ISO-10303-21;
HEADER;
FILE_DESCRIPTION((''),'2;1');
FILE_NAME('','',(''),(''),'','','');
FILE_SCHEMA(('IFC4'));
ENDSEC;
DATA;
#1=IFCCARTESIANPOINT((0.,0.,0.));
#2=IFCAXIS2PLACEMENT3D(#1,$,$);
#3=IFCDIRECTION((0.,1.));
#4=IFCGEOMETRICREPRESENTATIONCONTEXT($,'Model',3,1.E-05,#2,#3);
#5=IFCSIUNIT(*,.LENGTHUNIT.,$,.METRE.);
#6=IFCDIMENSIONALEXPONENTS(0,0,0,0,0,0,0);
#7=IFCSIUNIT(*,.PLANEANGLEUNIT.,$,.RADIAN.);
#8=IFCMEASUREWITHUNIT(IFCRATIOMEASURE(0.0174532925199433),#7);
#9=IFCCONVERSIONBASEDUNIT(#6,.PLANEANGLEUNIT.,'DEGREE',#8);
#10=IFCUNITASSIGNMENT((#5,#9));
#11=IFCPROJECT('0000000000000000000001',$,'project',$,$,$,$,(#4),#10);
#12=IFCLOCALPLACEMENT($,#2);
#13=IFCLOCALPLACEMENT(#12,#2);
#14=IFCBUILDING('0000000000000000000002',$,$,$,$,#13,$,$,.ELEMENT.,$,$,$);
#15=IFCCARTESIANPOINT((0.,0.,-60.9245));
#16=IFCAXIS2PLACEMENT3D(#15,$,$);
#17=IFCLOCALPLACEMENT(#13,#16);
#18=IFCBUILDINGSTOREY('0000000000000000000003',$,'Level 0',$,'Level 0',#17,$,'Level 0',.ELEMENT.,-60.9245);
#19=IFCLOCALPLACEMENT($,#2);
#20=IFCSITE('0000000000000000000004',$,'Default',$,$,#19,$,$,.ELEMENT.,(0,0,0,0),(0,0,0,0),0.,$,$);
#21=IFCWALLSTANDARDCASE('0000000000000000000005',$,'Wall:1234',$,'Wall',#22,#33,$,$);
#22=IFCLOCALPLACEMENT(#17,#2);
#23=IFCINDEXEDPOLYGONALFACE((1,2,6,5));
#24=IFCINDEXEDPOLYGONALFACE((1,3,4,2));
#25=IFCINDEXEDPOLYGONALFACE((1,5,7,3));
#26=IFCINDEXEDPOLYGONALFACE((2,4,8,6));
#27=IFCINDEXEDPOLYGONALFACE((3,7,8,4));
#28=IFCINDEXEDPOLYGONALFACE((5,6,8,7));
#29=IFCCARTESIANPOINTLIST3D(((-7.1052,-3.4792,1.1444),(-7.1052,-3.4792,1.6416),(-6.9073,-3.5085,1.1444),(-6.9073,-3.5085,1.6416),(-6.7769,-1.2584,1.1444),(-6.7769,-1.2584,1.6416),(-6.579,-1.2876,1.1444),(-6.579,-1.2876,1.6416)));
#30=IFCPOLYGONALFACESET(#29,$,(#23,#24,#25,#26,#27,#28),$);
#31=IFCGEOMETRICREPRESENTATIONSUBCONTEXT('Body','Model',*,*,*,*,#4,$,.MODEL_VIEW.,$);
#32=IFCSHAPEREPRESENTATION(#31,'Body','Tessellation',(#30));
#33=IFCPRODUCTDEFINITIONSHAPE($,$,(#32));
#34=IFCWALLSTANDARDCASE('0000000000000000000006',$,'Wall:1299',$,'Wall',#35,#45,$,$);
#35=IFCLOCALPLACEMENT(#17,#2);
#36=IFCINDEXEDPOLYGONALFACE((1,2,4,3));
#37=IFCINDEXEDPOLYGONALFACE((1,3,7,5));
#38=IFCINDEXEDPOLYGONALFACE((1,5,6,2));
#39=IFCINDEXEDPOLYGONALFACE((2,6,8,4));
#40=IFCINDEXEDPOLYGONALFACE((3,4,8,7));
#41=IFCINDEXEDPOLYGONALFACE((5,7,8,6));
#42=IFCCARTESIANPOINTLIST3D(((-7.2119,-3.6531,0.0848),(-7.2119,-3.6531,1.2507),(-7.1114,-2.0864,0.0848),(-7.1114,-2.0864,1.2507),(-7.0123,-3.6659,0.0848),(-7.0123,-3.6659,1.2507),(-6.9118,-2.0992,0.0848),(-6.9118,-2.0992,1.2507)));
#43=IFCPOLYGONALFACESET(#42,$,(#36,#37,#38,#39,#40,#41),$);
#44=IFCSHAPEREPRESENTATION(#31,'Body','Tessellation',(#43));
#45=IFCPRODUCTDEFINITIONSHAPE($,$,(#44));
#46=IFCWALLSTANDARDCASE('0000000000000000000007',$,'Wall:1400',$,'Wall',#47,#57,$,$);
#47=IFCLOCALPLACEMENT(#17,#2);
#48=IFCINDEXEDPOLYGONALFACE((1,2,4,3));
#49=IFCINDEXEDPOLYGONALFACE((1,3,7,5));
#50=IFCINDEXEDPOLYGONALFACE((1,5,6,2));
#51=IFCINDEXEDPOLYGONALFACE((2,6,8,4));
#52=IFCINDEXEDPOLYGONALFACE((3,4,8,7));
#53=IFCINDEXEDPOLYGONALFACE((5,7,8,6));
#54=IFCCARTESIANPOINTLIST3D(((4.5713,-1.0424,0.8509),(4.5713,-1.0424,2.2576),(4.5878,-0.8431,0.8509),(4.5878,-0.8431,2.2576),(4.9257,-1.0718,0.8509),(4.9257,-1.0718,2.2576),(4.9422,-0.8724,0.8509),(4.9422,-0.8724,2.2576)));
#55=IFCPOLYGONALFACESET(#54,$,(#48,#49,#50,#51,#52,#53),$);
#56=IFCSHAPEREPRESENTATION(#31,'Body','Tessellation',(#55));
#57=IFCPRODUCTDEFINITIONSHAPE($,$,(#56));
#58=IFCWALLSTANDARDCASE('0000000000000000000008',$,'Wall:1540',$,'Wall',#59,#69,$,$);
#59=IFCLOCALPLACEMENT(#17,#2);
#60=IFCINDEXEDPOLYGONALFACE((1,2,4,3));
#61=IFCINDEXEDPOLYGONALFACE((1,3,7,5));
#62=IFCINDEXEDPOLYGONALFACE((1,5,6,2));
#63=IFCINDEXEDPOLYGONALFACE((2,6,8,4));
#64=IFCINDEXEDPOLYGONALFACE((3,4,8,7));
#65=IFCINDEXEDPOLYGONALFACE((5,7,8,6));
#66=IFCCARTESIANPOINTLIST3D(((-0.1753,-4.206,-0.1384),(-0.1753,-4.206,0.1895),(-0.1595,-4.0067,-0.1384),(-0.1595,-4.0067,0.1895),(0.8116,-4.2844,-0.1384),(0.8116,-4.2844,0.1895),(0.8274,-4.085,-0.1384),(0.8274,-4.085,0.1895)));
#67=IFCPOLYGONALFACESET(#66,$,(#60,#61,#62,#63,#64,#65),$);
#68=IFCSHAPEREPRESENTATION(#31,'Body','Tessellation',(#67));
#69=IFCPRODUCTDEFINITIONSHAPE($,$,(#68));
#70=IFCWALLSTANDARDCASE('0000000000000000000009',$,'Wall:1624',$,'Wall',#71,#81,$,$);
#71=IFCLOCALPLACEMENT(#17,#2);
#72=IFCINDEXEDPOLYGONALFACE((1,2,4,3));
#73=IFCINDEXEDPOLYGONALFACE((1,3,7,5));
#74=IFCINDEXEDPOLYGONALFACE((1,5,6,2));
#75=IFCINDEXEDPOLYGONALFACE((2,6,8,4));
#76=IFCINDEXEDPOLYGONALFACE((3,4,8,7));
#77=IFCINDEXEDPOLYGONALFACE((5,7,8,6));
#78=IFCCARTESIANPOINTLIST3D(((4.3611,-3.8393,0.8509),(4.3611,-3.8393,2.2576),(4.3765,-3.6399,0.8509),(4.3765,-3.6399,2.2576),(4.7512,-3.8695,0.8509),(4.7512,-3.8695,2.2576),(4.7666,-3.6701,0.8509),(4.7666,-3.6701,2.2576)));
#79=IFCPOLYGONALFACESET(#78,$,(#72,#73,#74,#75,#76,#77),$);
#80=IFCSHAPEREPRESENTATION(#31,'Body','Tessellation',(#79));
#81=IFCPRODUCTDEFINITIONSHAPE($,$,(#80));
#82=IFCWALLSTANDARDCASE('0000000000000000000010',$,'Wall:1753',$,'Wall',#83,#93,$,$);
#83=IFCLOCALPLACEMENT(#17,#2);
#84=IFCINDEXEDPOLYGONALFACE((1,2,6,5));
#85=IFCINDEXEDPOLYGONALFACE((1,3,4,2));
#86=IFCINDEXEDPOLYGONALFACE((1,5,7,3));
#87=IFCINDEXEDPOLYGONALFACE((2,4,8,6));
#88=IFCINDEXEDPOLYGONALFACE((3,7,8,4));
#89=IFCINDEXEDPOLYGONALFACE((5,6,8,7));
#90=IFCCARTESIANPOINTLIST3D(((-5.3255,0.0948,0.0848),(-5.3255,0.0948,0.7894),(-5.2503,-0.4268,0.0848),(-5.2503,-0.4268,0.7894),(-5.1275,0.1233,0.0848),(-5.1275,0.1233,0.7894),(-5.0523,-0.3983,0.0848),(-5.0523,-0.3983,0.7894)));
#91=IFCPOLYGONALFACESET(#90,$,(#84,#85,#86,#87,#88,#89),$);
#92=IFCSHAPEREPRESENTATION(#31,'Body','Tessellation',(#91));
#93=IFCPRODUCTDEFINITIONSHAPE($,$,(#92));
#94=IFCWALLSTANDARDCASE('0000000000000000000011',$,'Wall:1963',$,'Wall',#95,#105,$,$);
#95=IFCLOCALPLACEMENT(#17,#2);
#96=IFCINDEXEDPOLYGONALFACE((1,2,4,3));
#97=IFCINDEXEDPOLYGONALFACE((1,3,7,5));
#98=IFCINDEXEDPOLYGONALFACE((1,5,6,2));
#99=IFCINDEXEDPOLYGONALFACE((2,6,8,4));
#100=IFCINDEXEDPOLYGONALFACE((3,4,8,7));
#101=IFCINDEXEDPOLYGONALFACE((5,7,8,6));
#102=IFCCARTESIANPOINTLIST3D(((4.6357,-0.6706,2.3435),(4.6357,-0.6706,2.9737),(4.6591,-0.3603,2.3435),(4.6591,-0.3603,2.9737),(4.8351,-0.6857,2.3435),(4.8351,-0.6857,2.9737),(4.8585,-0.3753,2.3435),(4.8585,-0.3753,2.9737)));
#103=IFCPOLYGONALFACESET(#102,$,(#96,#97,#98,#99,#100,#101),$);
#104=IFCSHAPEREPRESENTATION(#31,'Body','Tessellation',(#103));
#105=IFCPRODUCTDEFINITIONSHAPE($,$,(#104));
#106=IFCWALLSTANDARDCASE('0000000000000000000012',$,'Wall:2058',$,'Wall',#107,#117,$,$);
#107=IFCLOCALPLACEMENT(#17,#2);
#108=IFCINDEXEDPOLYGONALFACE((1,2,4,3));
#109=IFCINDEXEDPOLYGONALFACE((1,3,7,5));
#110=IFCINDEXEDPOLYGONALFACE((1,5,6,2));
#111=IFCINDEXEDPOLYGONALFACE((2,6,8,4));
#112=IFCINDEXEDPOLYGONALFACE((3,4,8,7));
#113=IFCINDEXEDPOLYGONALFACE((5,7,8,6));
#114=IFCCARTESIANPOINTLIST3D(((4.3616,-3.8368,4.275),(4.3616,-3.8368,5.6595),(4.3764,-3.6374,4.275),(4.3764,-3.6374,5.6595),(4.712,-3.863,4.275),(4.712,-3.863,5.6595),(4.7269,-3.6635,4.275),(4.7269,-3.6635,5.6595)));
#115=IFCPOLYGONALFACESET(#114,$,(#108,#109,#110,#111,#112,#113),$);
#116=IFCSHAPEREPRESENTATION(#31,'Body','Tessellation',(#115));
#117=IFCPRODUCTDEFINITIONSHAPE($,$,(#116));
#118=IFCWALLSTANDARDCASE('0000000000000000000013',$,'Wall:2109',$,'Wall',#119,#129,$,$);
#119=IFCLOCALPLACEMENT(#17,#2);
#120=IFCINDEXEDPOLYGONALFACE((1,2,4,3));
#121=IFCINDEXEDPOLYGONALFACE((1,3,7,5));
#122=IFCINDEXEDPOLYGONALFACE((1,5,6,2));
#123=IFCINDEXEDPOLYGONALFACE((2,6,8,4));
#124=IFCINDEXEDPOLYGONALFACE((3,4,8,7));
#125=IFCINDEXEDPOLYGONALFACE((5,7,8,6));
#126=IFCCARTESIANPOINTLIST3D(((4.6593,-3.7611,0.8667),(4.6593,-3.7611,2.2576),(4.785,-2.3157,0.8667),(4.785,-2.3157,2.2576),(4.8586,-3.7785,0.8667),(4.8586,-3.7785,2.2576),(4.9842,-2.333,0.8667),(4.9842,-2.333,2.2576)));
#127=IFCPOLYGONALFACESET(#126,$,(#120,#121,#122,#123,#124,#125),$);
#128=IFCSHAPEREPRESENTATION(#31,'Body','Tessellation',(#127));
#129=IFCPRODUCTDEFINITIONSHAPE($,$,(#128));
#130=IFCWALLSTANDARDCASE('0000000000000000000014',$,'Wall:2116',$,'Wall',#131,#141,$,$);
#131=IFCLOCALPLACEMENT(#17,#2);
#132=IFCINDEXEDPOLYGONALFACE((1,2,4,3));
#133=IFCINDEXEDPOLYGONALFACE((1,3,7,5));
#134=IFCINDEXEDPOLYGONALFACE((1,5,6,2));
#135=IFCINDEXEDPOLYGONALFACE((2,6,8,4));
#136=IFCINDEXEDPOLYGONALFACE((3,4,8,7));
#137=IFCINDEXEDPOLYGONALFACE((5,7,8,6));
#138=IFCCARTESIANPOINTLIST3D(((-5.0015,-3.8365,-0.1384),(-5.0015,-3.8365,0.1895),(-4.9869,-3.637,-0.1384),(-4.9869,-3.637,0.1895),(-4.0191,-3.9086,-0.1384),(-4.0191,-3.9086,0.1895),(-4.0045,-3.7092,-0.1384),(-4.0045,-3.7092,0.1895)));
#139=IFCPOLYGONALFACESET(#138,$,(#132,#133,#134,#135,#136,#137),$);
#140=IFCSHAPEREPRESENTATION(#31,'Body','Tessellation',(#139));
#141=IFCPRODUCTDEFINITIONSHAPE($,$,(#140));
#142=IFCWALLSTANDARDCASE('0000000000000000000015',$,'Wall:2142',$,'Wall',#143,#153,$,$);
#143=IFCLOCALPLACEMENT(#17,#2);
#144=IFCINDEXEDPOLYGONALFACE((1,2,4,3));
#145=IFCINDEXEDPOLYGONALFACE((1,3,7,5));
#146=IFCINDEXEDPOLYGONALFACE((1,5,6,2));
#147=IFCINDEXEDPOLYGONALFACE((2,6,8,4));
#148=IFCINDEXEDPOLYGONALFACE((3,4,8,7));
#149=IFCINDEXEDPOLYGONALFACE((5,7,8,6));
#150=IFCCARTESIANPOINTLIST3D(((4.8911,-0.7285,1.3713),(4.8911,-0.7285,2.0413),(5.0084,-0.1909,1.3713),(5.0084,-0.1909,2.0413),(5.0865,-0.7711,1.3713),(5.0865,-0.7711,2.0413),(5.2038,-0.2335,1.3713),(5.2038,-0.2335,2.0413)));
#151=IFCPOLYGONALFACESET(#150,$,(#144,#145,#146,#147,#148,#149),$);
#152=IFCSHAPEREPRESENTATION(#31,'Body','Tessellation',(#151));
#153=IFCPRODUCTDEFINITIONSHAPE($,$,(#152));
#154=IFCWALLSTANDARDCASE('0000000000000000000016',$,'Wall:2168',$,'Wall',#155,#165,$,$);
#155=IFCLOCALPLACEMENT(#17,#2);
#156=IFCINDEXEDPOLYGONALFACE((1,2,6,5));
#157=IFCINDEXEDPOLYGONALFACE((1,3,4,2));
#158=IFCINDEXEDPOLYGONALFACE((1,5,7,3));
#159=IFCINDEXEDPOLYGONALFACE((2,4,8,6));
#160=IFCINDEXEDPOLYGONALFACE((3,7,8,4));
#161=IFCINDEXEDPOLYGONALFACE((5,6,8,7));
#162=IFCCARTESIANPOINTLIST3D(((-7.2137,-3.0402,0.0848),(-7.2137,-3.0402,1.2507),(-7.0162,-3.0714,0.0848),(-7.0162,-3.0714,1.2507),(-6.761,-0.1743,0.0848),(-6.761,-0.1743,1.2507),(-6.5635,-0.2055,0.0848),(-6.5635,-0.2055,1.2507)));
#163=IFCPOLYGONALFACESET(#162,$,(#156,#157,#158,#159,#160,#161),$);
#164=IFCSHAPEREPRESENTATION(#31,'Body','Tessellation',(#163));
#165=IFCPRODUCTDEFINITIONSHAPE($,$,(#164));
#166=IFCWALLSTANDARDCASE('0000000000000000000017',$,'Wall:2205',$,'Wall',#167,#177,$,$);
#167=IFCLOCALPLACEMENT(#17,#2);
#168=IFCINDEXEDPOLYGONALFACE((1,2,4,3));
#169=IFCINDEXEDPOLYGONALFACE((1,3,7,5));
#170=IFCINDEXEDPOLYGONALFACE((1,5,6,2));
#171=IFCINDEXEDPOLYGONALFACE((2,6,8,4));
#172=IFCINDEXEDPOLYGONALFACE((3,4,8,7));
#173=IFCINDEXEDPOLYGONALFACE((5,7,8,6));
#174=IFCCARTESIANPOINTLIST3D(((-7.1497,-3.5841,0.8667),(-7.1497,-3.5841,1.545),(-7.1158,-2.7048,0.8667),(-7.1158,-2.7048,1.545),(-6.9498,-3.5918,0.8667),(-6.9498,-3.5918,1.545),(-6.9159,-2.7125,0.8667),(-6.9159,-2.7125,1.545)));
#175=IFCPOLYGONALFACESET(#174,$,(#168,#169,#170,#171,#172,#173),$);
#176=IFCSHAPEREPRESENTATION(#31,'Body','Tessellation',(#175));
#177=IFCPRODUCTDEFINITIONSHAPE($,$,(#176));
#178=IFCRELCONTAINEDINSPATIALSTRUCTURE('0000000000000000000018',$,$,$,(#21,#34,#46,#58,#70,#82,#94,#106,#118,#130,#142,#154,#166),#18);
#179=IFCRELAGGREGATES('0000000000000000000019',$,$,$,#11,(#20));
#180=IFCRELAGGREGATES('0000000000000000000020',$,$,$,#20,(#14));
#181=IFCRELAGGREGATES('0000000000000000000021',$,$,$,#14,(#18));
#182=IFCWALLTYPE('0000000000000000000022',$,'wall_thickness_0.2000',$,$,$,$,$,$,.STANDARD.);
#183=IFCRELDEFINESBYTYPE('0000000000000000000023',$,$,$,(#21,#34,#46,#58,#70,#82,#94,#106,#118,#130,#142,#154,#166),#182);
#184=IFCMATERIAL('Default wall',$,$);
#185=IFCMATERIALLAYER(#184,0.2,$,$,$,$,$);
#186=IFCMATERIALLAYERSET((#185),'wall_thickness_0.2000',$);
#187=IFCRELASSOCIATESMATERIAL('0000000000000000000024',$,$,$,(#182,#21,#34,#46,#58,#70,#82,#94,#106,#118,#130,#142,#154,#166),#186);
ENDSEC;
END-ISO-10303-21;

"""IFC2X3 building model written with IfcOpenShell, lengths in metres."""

from ifc_helpers import new_model, entity, si_unit, converted_unit, direction, frame, origin, place, context, subcontext, project, spatial, polyline, outline, extrude, material, layer, layer_set, layer_usage, type_object, element, save


model = new_model("IFC2X3")

# Units and contexts
model_context = context("Model", 3, precision=1e-05, world=origin(), true_north=direction((0.0, 1.0)))
body_context = subcontext(model_context, "Body", "Model", "MODEL_VIEW")
ifc_project = project(units=[si_unit("LENGTHUNIT", "METRE"), converted_unit("PLANEANGLEUNIT", "DEGREE", entity("IfcRatioMeasure", 0.0174532925199433), si_unit("PLANEANGLEUNIT", "RADIAN"), dimensions=[0, 0, 0, 0, 0, 0, 0])], contexts=[model_context])

# Site, building, storey
site_placement = place(None, origin())
site = spatial("IfcSite", under=ifc_project, at=site_placement, Name="Default", CompositionType="ELEMENT", RefLatitude=(0, 0, 0, 0), RefLongitude=(0, 0, 0, 0), RefElevation=0.0)
placement_1 = place(None, origin())
building_placement = place(placement_1, origin())
building = spatial("IfcBuilding", under=site, at=building_placement, CompositionType="ELEMENT")
storey_placement = place(building_placement, frame((0.0, 0.0, -60.9245)))
storey = spatial("IfcBuildingStorey", under=building, at=storey_placement, Name="Level 0", ObjectType="Level 0", LongName="Level 0", CompositionType="ELEMENT", Elevation=-60.9245)

# Walls
ifc_material = material(Name="Default wall")
ifc_layer = layer(ifc_material, 0.2)
ifc_layer_set = layer_set([ifc_layer], Name="wall_thickness_0.2000")
ifc_layer_usage = layer_usage(ifc_layer_set, "AXIS2", "POSITIVE", -0.1)
wall_type = type_object("IfcWallType", Name="wall_thickness_0.2000", PredefinedType="STANDARD", material=ifc_layer_set)
placement_2 = place(building_placement, frame((0.0, 0.0, -59.7801)))
wall_1_placement = place(placement_2, frame((-7.0063, -3.4939, 0.0), z_axis=(0.0, 0.0, 1.0), x_axis=(0.146234, 0.98925, 0.0)))
element("IfcWallStandardCase", 1, at=wall_1_placement, inside=storey, type_object=wall_type, material=ifc_layer_usage, Name="Wall:1234", ObjectType="Wall", context=body_context, shape_type="SweptSolid", body=[
    extrude(outline(polyline([(2.245, -0.1), (2.245, 0.1), (0.0, 0.1), (0.0, -0.1), (2.245, -0.1)])), origin(), (0.0, 0.0, 1.0), 0.4972),
])
placement_3 = place(building_placement, frame((0.0, 0.0, -60.8397)))
wall_2_placement = place(placement_3, frame((-7.0116, -2.0928, 0.0), z_axis=(0.0, 0.0, 1.0), x_axis=(-0.064008, -0.997949, 0.0)))
element("IfcWallStandardCase", 2, at=wall_2_placement, inside=storey, type_object=wall_type, material=ifc_layer_usage, Name="Wall:1299", ObjectType="Wall", context=body_context, shape_type="SweptSolid", body=[
    extrude(outline(polyline([(1.57, -0.1), (1.57, 0.1), (0.0, 0.1), (0.0, -0.1), (1.57, -0.1)])), origin(), (0.0, 0.0, 1.0), 1.1659),
])
placement_4 = place(building_placement, frame((0.0, 0.0, -60.0736)))
wall_3_placement = place(placement_4, frame((4.934, -0.9721, 0.0), z_axis=(0.0, 0.0, 1.0), x_axis=(-0.996596, 0.08244, 0.0)))
element("IfcWallStandardCase", 3, at=wall_3_placement, inside=storey, type_object=wall_type, material=ifc_layer_usage, Name="Wall:1400", ObjectType="Wall", context=body_context, shape_type="SweptSolid", body=[
    extrude(outline(polyline([(0.3556, -0.1), (0.3556, 0.1), (0.0, 0.1), (0.0, -0.1), (0.3556, -0.1)])), origin(), (0.0, 0.0, 1.0), 1.4068),
])
placement_5 = place(building_placement, frame((0.0, 0.0, -61.0629)))
wall_4_placement = place(placement_5, frame((-0.1674, -4.1064, 0.0), z_axis=(0.0, 0.0, 1.0), x_axis=(0.996862, -0.079155, 0.0)))
element("IfcWallStandardCase", 4, at=wall_4_placement, inside=storey, type_object=wall_type, material=ifc_layer_usage, Name="Wall:1540", ObjectType="Wall", context=body_context, shape_type="SweptSolid", body=[
    extrude(outline(polyline([(0.99, -0.1), (0.99, 0.1), (0.0, 0.1), (0.0, -0.1), (0.99, -0.1)])), origin(), (0.0, 0.0, 1.0), 0.3279),
])
placement_6 = place(building_placement, frame((0.0, 0.0, -60.0736)))
wall_5_placement = place(placement_6, frame((4.7589, -3.7698, 0.0), z_axis=(0.0, 0.0, 1.0), x_axis=(-0.997016, 0.077196, 0.0)))
element("IfcWallStandardCase", 5, at=wall_5_placement, inside=storey, type_object=wall_type, material=ifc_layer_usage, Name="Wall:1624", ObjectType="Wall", context=body_context, shape_type="SweptSolid", body=[
    extrude(outline(polyline([(0.3913, -0.1), (0.3913, 0.1), (0.0, 0.1), (0.0, -0.1), (0.3913, -0.1)])), origin(), (0.0, 0.0, 1.0), 1.4068),
])
placement_7 = place(building_placement, frame((0.0, 0.0, -60.8397)))
wall_6_placement = place(placement_7, frame((-5.1513, -0.4126, 0.0), z_axis=(0.0, 0.0, 1.0), x_axis=(-0.142777, 0.989755, 0.0)))
element("IfcWallStandardCase", 6, at=wall_6_placement, inside=storey, type_object=wall_type, material=ifc_layer_usage, Name="Wall:1753", ObjectType="Wall", context=body_context, shape_type="SweptSolid", body=[
    extrude(outline(polyline([(0.527, -0.1), (0.527, 0.1), (0.0, 0.1), (0.0, -0.1), (0.527, -0.1)])), origin(), (0.0, 0.0, 1.0), 0.7047),
])
placement_8 = place(building_placement, frame((0.0, 0.0, -58.581)))
wall_7_placement = place(placement_8, frame((4.7588, -0.3678, 0.0), z_axis=(0.0, 0.0, 1.0), x_axis=(-0.075225, -0.997167, 0.0)))
element("IfcWallStandardCase", 7, at=wall_7_placement, inside=storey, type_object=wall_type, material=ifc_layer_usage, Name="Wall:1963", ObjectType="Wall", context=body_context, shape_type="SweptSolid", body=[
    extrude(outline(polyline([(0.3113, -0.1), (0.3113, 0.1), (0.0, 0.1), (0.0, -0.1), (0.3113, -0.1)])), origin(), (0.0, 0.0, 1.0), 0.6302),
])
placement_9 = place(building_placement, frame((0.0, 0.0, -56.6495)))
wall_8_placement = place(placement_9, frame((4.7195, -3.7632, 0.0), z_axis=(0.0, 0.0, 1.0), x_axis=(-0.997237, 0.074284, 0.0)))
element("IfcWallStandardCase", 8, at=wall_8_placement, inside=storey, type_object=wall_type, material=ifc_layer_usage, Name="Wall:2058", ObjectType="Wall", context=body_context, shape_type="SweptSolid", body=[
    extrude(outline(polyline([(0.3515, -0.1), (0.3515, 0.1), (0.0, 0.1), (0.0, -0.1), (0.3515, -0.1)])), origin(), (0.0, 0.0, 1.0), 1.3845),
])
placement_10 = place(building_placement, frame((0.0, 0.0, -60.0578)))
wall_9_placement = place(placement_10, frame((4.8846, -2.3244, 0.0), z_axis=(0.0, 0.0, 1.0), x_axis=(-0.086633, -0.99624, 0.0)))
element("IfcWallStandardCase", 9, at=wall_9_placement, inside=storey, type_object=wall_type, material=ifc_layer_usage, Name="Wall:2109", ObjectType="Wall", context=body_context, shape_type="SweptSolid", body=[
    extrude(outline(polyline([(1.4509, -0.1), (1.4509, 0.1), (0.0, 0.1), (0.0, -0.1), (1.4509, -0.1)])), origin(), (0.0, 0.0, 1.0), 1.3909),
])
placement_11 = place(building_placement, frame((0.0, 0.0, -61.0629)))
wall_10_placement = place(placement_11, frame((-4.9942, -3.7368, 0.0), z_axis=(0.0, 0.0, 1.0), x_axis=(0.997317, -0.0732, 0.0)))
element("IfcWallStandardCase", 10, at=wall_10_placement, inside=storey, type_object=wall_type, material=ifc_layer_usage, Name="Wall:2116", ObjectType="Wall", context=body_context, shape_type="SweptSolid", body=[
    extrude(outline(polyline([(0.985, -0.1), (0.985, 0.1), (0.0, 0.1), (0.0, -0.1), (0.985, -0.1)])), origin(), (0.0, 0.0, 1.0), 0.3279),
])
placement_12 = place(building_placement, frame((0.0, 0.0, -59.5532)))
wall_11_placement = place(placement_12, frame((5.1061, -0.2122, 0.0), z_axis=(0.0, 0.0, 1.0), x_axis=(-0.21324, -0.977, 0.0)))
element("IfcWallStandardCase", 11, at=wall_11_placement, inside=storey, type_object=wall_type, material=ifc_layer_usage, Name="Wall:2142", ObjectType="Wall", context=body_context, shape_type="SweptSolid", body=[
    extrude(outline(polyline([(0.5503, -0.1), (0.5503, 0.1), (0.0, 0.1), (0.0, -0.1), (0.5503, -0.1)])), origin(), (0.0, 0.0, 1.0), 0.67),
])
placement_13 = place(building_placement, frame((0.0, 0.0, -60.8397)))
wall_12_placement = place(placement_13, frame((-7.1149, -3.0558, 0.0), z_axis=(0.0, 0.0, 1.0), x_axis=(0.156019, 0.987754, 0.0)))
element("IfcWallStandardCase", 12, at=wall_12_placement, inside=storey, type_object=wall_type, material=ifc_layer_usage, Name="Wall:2168", ObjectType="Wall", context=body_context, shape_type="SweptSolid", body=[
    extrude(outline(polyline([(2.9014, -0.1), (2.9014, 0.1), (0.0, 0.1), (0.0, -0.1), (2.9014, -0.1)])), origin(), (0.0, 0.0, 1.0), 1.1659),
])
placement_14 = place(building_placement, frame((0.0, 0.0, -60.0578)))
wall_13_placement = place(placement_14, frame((-7.0498, -3.588, 0.0), z_axis=(0.0, 0.0, 1.0), x_axis=(0.038546, 0.999257, 0.0)))
element("IfcWallStandardCase", 13, at=wall_13_placement, inside=storey, type_object=wall_type, material=ifc_layer_usage, Name="Wall:2205", ObjectType="Wall", context=body_context, shape_type="SweptSolid", body=[
    extrude(outline(polyline([(0.88, -0.1), (0.88, 0.1), (0.0, 0.1), (0.0, -0.1), (0.88, -0.1)])), origin(), (0.0, 0.0, 1.0), 0.6783),
])

save(model, "model.ifc")
